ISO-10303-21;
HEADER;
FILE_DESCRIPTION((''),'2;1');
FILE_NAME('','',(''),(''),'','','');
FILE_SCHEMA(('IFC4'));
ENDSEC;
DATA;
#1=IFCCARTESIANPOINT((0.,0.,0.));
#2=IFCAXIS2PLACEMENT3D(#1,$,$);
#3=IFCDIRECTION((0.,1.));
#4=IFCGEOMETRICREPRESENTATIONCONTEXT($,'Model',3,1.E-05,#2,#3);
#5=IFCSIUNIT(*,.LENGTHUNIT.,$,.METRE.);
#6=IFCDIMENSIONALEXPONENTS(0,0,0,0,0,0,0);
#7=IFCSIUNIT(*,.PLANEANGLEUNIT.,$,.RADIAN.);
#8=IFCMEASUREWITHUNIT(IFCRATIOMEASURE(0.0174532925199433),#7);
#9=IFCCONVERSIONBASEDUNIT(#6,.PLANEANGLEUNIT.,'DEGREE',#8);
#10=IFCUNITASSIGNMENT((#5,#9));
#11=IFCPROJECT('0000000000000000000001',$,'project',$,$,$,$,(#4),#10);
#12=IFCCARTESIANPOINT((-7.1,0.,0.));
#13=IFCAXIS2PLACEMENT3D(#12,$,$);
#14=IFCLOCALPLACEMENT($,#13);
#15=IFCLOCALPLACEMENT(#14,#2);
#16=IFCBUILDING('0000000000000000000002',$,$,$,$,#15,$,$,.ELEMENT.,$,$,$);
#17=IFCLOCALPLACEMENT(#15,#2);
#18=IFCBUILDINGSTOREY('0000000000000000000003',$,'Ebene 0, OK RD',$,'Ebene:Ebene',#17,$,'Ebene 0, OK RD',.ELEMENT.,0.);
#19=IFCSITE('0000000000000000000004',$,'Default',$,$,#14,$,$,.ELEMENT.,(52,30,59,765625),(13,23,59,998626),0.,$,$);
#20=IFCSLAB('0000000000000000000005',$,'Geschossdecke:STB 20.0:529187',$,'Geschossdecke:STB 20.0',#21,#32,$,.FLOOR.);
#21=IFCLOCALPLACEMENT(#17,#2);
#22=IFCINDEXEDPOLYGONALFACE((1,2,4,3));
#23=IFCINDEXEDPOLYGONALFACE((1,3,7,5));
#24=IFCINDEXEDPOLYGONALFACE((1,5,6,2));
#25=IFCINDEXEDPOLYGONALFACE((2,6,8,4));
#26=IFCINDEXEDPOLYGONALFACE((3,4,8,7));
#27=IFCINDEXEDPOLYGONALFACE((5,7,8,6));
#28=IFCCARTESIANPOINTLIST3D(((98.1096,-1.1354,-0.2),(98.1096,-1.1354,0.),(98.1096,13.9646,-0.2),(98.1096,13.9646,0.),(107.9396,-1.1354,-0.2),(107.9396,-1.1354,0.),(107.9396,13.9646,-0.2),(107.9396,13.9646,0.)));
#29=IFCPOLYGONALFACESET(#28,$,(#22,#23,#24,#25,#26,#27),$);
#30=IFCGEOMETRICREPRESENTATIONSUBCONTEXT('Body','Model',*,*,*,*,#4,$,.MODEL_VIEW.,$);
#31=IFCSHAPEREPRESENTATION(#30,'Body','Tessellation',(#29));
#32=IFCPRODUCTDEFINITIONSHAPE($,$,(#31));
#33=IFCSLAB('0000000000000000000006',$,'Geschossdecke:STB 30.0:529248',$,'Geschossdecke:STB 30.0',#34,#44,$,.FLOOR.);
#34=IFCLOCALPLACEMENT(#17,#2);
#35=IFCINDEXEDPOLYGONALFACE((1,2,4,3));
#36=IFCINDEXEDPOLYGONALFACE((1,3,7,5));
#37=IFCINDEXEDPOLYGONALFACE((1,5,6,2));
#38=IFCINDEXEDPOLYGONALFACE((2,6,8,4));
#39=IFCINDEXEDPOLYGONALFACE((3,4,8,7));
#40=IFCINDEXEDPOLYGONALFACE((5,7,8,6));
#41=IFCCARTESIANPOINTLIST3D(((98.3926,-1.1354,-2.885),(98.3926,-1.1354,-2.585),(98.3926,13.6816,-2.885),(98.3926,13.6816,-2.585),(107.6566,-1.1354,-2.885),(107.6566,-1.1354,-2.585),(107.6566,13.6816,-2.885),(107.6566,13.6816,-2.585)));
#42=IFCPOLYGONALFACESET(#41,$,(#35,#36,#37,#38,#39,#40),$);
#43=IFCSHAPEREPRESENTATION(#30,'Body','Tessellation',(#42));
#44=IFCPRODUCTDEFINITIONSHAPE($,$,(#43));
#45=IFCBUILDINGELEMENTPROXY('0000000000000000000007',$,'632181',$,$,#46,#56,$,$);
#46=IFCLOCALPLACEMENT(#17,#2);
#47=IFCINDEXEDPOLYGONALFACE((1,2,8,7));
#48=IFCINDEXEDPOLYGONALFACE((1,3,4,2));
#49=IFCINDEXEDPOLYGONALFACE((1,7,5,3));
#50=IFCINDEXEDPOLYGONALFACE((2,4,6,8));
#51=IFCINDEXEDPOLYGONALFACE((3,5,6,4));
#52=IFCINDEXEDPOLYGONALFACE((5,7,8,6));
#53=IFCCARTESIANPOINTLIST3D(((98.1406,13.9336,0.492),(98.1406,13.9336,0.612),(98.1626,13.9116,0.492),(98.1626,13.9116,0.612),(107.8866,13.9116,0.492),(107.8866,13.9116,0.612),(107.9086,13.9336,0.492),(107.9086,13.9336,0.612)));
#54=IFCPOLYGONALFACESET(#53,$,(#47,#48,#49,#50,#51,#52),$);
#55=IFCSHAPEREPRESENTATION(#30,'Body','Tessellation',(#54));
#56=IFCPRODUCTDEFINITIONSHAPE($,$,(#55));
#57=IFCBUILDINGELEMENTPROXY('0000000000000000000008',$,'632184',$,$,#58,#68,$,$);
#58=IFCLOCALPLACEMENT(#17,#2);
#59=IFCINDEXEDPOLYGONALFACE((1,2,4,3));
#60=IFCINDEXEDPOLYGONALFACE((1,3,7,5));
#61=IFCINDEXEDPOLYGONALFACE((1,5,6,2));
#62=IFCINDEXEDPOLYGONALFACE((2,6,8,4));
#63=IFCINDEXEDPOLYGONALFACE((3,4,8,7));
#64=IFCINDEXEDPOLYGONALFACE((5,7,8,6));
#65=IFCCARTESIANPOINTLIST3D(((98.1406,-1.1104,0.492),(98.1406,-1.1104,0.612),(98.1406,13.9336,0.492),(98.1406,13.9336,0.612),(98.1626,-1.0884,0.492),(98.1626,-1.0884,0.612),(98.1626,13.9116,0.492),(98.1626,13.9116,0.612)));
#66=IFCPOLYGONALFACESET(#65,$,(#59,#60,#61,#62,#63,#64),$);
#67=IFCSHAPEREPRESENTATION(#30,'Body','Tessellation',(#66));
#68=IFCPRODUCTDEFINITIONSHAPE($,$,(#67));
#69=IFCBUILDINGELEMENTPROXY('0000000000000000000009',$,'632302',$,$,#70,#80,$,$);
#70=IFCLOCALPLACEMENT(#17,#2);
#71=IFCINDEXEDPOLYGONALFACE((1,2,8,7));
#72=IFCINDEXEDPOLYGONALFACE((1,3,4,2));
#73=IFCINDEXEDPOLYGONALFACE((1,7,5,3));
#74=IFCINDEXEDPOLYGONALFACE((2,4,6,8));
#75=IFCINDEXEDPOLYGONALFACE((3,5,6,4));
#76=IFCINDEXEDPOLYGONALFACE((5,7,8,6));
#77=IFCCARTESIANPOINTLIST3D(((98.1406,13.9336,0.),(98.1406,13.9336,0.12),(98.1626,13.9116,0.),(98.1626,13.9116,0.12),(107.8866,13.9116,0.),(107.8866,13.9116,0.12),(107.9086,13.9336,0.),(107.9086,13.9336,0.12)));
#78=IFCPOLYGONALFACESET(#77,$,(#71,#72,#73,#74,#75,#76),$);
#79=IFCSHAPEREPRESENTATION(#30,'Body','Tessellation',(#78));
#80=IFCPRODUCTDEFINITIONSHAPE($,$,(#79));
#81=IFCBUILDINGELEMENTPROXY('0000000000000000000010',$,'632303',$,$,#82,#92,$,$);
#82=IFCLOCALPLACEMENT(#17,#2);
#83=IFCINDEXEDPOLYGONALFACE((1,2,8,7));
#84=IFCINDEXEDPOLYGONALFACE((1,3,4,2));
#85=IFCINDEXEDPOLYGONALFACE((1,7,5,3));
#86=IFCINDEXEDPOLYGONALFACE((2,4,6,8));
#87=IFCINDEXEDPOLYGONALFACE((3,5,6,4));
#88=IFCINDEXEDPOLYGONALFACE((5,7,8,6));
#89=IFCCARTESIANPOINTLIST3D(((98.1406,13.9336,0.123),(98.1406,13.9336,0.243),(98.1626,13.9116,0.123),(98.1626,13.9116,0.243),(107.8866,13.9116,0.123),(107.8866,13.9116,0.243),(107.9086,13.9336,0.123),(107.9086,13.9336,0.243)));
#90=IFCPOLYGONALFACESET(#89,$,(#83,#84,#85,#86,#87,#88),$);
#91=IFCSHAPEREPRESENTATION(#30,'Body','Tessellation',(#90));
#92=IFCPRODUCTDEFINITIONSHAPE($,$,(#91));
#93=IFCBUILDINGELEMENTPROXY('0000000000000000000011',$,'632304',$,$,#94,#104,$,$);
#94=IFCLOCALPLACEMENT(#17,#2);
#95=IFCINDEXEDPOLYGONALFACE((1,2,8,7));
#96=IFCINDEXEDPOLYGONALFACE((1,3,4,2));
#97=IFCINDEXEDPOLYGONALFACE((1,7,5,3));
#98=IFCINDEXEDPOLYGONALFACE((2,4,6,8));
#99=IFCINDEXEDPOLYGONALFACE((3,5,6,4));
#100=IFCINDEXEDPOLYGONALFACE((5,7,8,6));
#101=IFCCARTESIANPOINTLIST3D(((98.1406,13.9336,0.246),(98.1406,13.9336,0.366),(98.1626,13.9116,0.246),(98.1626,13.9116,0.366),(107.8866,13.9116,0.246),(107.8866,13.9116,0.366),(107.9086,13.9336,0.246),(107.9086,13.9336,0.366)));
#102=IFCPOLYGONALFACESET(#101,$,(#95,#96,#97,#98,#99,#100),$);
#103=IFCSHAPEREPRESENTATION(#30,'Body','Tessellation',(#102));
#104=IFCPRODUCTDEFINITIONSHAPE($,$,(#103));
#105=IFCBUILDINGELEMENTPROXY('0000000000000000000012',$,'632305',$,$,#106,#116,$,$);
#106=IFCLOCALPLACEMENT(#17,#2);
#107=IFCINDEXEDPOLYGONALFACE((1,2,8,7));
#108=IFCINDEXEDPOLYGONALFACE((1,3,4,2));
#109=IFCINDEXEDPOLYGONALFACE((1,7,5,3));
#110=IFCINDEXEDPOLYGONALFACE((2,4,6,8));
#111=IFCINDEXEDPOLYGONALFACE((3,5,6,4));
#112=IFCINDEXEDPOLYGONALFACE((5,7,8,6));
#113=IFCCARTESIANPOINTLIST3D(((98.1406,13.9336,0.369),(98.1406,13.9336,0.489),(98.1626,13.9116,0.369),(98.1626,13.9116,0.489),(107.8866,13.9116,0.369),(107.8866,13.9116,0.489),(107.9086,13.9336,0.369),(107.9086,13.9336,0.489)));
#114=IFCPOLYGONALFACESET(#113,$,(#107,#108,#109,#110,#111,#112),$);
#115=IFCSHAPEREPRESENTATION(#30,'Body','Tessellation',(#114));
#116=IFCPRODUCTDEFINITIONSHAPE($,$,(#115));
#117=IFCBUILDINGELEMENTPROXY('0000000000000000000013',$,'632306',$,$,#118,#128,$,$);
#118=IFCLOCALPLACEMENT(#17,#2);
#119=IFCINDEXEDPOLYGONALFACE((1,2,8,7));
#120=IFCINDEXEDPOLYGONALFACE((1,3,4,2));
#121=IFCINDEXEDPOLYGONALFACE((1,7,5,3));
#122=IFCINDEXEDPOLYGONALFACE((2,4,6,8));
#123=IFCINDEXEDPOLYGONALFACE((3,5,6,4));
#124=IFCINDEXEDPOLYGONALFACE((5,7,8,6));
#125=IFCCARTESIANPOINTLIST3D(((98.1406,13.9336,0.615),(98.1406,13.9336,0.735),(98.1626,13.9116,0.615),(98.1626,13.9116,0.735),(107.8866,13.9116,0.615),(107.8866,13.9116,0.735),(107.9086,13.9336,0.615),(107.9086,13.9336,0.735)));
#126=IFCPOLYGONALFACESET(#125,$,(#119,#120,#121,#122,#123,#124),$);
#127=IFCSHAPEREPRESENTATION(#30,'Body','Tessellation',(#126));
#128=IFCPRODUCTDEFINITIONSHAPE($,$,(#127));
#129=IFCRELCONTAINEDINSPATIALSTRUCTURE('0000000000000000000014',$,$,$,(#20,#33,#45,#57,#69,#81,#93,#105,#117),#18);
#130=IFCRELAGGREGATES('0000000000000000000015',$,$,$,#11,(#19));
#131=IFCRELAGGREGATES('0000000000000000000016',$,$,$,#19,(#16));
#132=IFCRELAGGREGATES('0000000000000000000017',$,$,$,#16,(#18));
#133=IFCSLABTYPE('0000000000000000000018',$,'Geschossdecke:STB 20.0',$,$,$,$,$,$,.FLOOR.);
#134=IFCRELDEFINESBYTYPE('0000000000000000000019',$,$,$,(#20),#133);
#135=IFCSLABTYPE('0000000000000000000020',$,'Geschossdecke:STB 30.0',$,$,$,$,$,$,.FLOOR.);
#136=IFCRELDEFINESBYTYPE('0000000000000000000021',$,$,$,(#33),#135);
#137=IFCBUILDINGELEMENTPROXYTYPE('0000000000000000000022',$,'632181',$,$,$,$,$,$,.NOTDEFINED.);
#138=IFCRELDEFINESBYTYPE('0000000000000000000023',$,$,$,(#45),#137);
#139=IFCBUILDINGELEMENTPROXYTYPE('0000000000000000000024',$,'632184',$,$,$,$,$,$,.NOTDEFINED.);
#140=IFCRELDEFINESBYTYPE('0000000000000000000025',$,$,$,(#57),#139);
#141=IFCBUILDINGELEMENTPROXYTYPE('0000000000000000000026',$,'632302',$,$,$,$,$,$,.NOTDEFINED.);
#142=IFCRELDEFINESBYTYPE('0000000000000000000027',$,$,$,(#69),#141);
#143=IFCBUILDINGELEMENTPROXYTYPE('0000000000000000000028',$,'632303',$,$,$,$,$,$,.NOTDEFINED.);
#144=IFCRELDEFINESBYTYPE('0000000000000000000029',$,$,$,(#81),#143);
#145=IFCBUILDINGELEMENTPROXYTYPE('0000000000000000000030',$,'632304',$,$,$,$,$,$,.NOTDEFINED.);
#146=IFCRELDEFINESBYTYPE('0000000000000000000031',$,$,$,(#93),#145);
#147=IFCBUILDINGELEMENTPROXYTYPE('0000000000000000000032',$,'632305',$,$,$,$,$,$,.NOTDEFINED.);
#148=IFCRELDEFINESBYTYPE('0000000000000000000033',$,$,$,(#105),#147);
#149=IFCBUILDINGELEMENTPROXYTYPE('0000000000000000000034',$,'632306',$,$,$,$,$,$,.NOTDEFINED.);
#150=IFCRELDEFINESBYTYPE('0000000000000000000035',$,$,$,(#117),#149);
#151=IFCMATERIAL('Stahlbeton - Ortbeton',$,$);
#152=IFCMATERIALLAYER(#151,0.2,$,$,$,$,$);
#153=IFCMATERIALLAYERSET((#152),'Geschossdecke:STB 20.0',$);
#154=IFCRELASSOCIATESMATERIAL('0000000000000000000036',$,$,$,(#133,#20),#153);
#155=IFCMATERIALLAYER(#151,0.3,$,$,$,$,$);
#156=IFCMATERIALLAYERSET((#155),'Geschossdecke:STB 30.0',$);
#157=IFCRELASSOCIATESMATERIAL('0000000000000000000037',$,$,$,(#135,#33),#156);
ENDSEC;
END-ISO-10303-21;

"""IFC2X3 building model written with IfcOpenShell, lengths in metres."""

from ifc_helpers import new_model, entity, si_unit, converted_unit, direction, frame, frame_2d, origin, origin_2d_with_axis, place, context, subcontext, project, spatial, polyline, rectangle, outline, extrude, material, layer, layer_set, layer_usage, type_object, element, save


model = new_model("IFC2X3")

# Units and contexts
model_context = context("Model", 3, precision=1e-05, world=origin(), true_north=direction((0.0, 1.0)))
body_context = subcontext(model_context, "Body", "Model", "MODEL_VIEW")
ifc_project = project(units=[si_unit("LENGTHUNIT", "METRE"), converted_unit("PLANEANGLEUNIT", "DEGREE", entity("IfcRatioMeasure", 0.0174532925199433), si_unit("PLANEANGLEUNIT", "RADIAN"), dimensions=[0, 0, 0, 0, 0, 0, 0])], contexts=[model_context])

# Site, building, storey
site_placement = place(None, frame((-7.1, 0.0, 0.0)))
site = spatial("IfcSite", under=ifc_project, at=site_placement, Name="Default", CompositionType="ELEMENT", RefLatitude=(52, 30, 59, 765625), RefLongitude=(13, 23, 59, 998626), RefElevation=0.0)
building_placement = place(site_placement, origin())
building = spatial("IfcBuilding", under=site, at=building_placement, CompositionType="ELEMENT")
storey_placement = place(building_placement, origin())
storey = spatial("IfcBuildingStorey", under=building, at=storey_placement, Name="Ebene 0, OK RD", ObjectType="Ebene:Ebene", LongName="Ebene 0, OK RD", CompositionType="ELEMENT", Elevation=0.0)

# Slabs
ifc_material_1 = material(Name="Stahlbeton - Ortbeton")
ifc_layer_1 = layer(ifc_material_1, 0.2)
ifc_layer_set_1 = layer_set([ifc_layer_1], Name="Geschossdecke:STB 20.0")
ifc_layer_usage_1 = layer_usage(ifc_layer_set_1, "AXIS3", "POSITIVE", 0.0)
slab_type_1 = type_object("IfcSlabType", Name="Geschossdecke:STB 20.0", PredefinedType="FLOOR", material=ifc_layer_set_1)
slab_1_placement = place(storey_placement, origin())
element("IfcSlab", 1, at=slab_1_placement, inside=storey, type_object=slab_type_1, material=ifc_layer_usage_1, Name="Geschossdecke:STB 20.0:529187", ObjectType="Geschossdecke:STB 20.0", PredefinedType="FLOOR", context=body_context, shape_type="SweptSolid", body=[
    extrude(rectangle(XDim=15.1, YDim=9.83, at=origin_2d_with_axis()), frame((103.0246, 6.4146, 0.0), z_axis=(0.0, 0.0, -1.0), x_axis=(0.0, 1.0, 0.0)), (0.0, 0.0, 1.0), 0.2),
])
ifc_layer_2 = layer(ifc_material_1, 0.3)
ifc_layer_set_2 = layer_set([ifc_layer_2], Name="Geschossdecke:STB 30.0")
ifc_layer_usage_2 = layer_usage(ifc_layer_set_2, "AXIS3", "POSITIVE", 0.0)
slab_type_2 = type_object("IfcSlabType", Name="Geschossdecke:STB 30.0", PredefinedType="FLOOR", material=ifc_layer_set_2)
slab_2_placement = place(storey_placement, origin())
element("IfcSlab", 2, at=slab_2_placement, inside=storey, type_object=slab_type_2, material=ifc_layer_usage_2, Name="Geschossdecke:STB 30.0:529248", ObjectType="Geschossdecke:STB 30.0", PredefinedType="FLOOR", context=body_context, shape_type="SweptSolid", body=[
    extrude(rectangle(XDim=14.817, YDim=9.264, at=frame_2d((0.0, 0.0), x_axis=(1.0, 0.0))), frame((103.0246, 6.2731, -2.585), z_axis=(0.0, 0.0, -1.0), x_axis=(0.0, 1.0, 0.0)), (0.0, 0.0, 1.0), 0.3),
])

# Building element proxies
building_element_proxy_type_1 = type_object("IfcBuildingElementProxyType", Name="632181", PredefinedType="NOTDEFINED")
proxy_1_placement = place(storey_placement, origin())
element("IfcBuildingElementProxy", 3, at=proxy_1_placement, inside=storey, type_object=building_element_proxy_type_1, Name="632181", context=body_context, shape_type="SweptSolid", body=[
    extrude(outline(polyline([(-4.862, -0.011), (4.862, -0.011), (4.884, 0.011), (-4.884, 0.011), (-4.862, -0.011)])), frame((103.0246, 13.9226, 0.492)), (0.0, 0.0, 1.0), 0.12),
])
building_element_proxy_type_2 = type_object("IfcBuildingElementProxyType", Name="632184", PredefinedType="NOTDEFINED")
proxy_2_placement = place(storey_placement, origin())
element("IfcBuildingElementProxy", 4, at=proxy_2_placement, inside=storey, type_object=building_element_proxy_type_2, Name="632184", context=body_context, shape_type="SweptSolid", body=[
    extrude(outline(polyline([(-7.5, -0.011), (7.5, -0.011), (7.522, 0.011), (-7.522, 0.011), (-7.5, -0.011)])), frame((98.1516, 6.4116, 0.492), z_axis=(0.0, 0.0, 1.0), x_axis=(0.0, 1.0, 0.0)), (0.0, 0.0, 1.0), 0.12),
])
building_element_proxy_type_3 = type_object("IfcBuildingElementProxyType", Name="632302", PredefinedType="NOTDEFINED")
proxy_3_placement = place(storey_placement, origin())
element("IfcBuildingElementProxy", 5, at=proxy_3_placement, inside=storey, type_object=building_element_proxy_type_3, Name="632302", context=body_context, shape_type="SweptSolid", body=[
    extrude(outline(polyline([(-4.862, -0.011), (4.862, -0.011), (4.884, 0.011), (-4.884, 0.011), (-4.862, -0.011)])), frame((103.0246, 13.9226, 0.0)), (0.0, 0.0, 1.0), 0.12),
])
building_element_proxy_type_4 = type_object("IfcBuildingElementProxyType", Name="632303", PredefinedType="NOTDEFINED")
proxy_4_placement = place(storey_placement, origin())
element("IfcBuildingElementProxy", 6, at=proxy_4_placement, inside=storey, type_object=building_element_proxy_type_4, Name="632303", context=body_context, shape_type="SweptSolid", body=[
    extrude(outline(polyline([(-4.862, -0.011), (4.862, -0.011), (4.884, 0.011), (-4.884, 0.011), (-4.862, -0.011)])), frame((103.0246, 13.9226, 0.123)), (0.0, 0.0, 1.0), 0.12),
])
building_element_proxy_type_5 = type_object("IfcBuildingElementProxyType", Name="632304", PredefinedType="NOTDEFINED")
proxy_5_placement = place(storey_placement, origin())
element("IfcBuildingElementProxy", 7, at=proxy_5_placement, inside=storey, type_object=building_element_proxy_type_5, Name="632304", context=body_context, shape_type="SweptSolid", body=[
    extrude(outline(polyline([(-4.862, -0.011), (4.862, -0.011), (4.884, 0.011), (-4.884, 0.011), (-4.862, -0.011)])), frame((103.0246, 13.9226, 0.246)), (0.0, 0.0, 1.0), 0.12),
])
building_element_proxy_type_6 = type_object("IfcBuildingElementProxyType", Name="632305", PredefinedType="NOTDEFINED")
proxy_6_placement = place(storey_placement, origin())
element("IfcBuildingElementProxy", 8, at=proxy_6_placement, inside=storey, type_object=building_element_proxy_type_6, Name="632305", context=body_context, shape_type="SweptSolid", body=[
    extrude(outline(polyline([(-4.862, -0.011), (4.862, -0.011), (4.884, 0.011), (-4.884, 0.011), (-4.862, -0.011)])), frame((103.0246, 13.9226, 0.369)), (0.0, 0.0, 1.0), 0.12),
])
building_element_proxy_type_7 = type_object("IfcBuildingElementProxyType", Name="632306", PredefinedType="NOTDEFINED")
proxy_7_placement = place(storey_placement, origin())
element("IfcBuildingElementProxy", 9, at=proxy_7_placement, inside=storey, type_object=building_element_proxy_type_7, Name="632306", context=body_context, shape_type="SweptSolid", body=[
    extrude(outline(polyline([(-4.862, -0.011), (4.862, -0.011), (4.884, 0.011), (-4.884, 0.011), (-4.862, -0.011)])), frame((103.0246, 13.9226, 0.615)), (0.0, 0.0, 1.0), 0.12),
])

save(model, "model.ifc")
